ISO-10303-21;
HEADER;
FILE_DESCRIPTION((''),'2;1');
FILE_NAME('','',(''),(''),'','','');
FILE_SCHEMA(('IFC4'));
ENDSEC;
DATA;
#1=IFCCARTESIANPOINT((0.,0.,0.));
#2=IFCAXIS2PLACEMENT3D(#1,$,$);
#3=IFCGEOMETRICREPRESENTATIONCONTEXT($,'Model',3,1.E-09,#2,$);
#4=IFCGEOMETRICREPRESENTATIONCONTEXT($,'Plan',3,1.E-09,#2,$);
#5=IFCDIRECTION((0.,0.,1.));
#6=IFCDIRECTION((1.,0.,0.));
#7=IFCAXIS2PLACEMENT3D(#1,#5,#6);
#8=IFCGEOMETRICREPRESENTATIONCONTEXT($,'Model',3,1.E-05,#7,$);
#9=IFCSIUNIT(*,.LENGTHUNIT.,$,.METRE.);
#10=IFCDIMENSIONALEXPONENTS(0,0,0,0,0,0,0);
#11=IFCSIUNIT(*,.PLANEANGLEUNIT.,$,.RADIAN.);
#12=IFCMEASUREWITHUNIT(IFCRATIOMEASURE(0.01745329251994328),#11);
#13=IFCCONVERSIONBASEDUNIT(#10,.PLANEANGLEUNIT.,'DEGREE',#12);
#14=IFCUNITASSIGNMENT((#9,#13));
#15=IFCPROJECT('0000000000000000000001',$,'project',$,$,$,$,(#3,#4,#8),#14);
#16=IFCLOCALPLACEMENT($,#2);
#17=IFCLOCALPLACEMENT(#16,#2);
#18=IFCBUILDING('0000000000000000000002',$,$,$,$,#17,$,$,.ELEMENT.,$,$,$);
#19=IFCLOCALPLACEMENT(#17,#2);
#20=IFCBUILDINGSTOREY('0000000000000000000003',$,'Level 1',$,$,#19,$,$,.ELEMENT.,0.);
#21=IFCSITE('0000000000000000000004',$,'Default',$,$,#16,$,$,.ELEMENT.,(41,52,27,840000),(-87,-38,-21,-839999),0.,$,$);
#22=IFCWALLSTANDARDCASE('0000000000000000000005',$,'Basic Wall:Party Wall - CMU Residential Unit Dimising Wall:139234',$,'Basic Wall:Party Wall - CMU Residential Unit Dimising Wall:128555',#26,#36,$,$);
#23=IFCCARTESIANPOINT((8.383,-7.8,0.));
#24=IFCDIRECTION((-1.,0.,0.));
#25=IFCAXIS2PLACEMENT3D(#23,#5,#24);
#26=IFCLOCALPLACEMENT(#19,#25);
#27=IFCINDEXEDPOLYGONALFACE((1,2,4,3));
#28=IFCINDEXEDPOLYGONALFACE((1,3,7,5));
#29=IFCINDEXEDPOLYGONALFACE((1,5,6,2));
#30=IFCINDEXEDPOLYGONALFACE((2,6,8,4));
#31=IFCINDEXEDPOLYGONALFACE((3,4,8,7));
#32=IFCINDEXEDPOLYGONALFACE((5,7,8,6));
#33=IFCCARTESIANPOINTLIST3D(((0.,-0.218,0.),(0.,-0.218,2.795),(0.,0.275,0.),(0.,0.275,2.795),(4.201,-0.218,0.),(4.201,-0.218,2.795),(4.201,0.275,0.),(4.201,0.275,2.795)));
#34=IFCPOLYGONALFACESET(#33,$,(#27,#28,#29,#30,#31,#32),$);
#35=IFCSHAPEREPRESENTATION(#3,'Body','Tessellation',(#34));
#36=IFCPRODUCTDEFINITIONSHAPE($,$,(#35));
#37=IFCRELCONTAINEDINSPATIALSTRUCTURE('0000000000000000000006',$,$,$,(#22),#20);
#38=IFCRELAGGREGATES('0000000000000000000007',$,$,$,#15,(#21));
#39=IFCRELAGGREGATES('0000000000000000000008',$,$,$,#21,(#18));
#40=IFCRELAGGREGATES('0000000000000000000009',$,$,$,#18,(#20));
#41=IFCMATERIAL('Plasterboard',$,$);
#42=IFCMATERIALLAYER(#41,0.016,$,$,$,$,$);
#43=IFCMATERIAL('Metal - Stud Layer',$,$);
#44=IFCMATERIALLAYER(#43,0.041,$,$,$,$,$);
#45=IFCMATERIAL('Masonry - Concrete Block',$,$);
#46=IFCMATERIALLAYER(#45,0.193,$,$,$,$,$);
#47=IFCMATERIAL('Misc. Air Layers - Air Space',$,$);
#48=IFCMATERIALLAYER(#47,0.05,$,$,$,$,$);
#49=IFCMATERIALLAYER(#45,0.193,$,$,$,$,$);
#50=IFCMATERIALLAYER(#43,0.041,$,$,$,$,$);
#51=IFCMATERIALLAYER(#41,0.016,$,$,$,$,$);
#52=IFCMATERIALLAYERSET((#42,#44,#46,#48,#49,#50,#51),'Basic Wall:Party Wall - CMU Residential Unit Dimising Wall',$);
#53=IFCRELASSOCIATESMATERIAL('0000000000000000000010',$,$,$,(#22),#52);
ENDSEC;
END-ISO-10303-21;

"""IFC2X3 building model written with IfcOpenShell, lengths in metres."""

from ifc_helpers import new_model, entity, si_unit, converted_unit, frame, frame_2d, origin, origin_with_axes, place, context, project, spatial, polyline, rectangle, extrude, clip, bounded_halfspace, material, layer, layer_set, layer_usage, element, save


model = new_model("IFC2X3")

# Units and contexts
model_context_1 = context("Model", 3, precision=1e-09, world=origin())
plan_context = context("Plan", 3, precision=1e-09, world=origin())
model_context_2 = context("Model", 3, precision=1e-05, world=origin_with_axes())
ifc_project = project(units=[si_unit("LENGTHUNIT", "METRE"), converted_unit("PLANEANGLEUNIT", "DEGREE", entity("IfcRatioMeasure", 0.01745329251994328), si_unit("PLANEANGLEUNIT", "RADIAN"), dimensions=[0, 0, 0, 0, 0, 0, 0])], contexts=[model_context_1, plan_context, model_context_2])

# Site, building, storey
site_placement = place(None, origin())
site = spatial("IfcSite", under=ifc_project, at=site_placement, Name="Default", CompositionType="ELEMENT", RefLatitude=(41, 52, 27, 840000), RefLongitude=(-87, -38, -21, -839999), RefElevation=0.0)
building_placement = place(site_placement, origin())
building = spatial("IfcBuilding", under=site, at=building_placement, CompositionType="ELEMENT")
storey_placement = place(building_placement, origin())
storey = spatial("IfcBuildingStorey", under=building, at=storey_placement, Name="Level 1", CompositionType="ELEMENT", Elevation=0.0)

# Wall
ifc_material_1 = material(Name="Plasterboard")
ifc_layer_1 = layer(ifc_material_1, 0.016)
ifc_material_2 = material(Name="Metal - Stud Layer")
ifc_layer_2 = layer(ifc_material_2, 0.041)
ifc_material_3 = material(Name="Masonry - Concrete Block")
ifc_layer_3 = layer(ifc_material_3, 0.193)
ifc_material_4 = material(Name="Misc. Air Layers - Air Space")
ifc_layer_4 = layer(ifc_material_4, 0.05)
ifc_layer_5 = layer(ifc_material_3, 0.193)
ifc_layer_6 = layer(ifc_material_2, 0.041)
ifc_layer_7 = layer(ifc_material_1, 0.016)
ifc_layer_set_1 = layer_set([ifc_layer_1, ifc_layer_2, ifc_layer_3, ifc_layer_4, ifc_layer_5, ifc_layer_6, ifc_layer_7], Name="Basic Wall:Party Wall - CMU Residential Unit Dimising Wall")
ifc_layer_usage_1 = layer_usage(ifc_layer_set_1, "AXIS2", "NEGATIVE", 0.275)
wall_1_placement = place(storey_placement, frame((8.383, -7.8, 0.0), z_axis=(0.0, 0.0, 1.0), x_axis=(-1.0, 0.0, 0.0)))
element("IfcWallStandardCase", 1, at=wall_1_placement, inside=storey, material=ifc_layer_usage_1, Name="Basic Wall:Party Wall - CMU Residential Unit Dimising Wall:139234", ObjectType="Basic Wall:Party Wall - CMU Residential Unit Dimising Wall:128555", context=model_context_1, shape_type="Clipping", body=[
    clip(clip(extrude(rectangle(XDim=4.201, YDim=0.55, at=frame_2d((2.1005, 0.0), x_axis=(-1.0, 0.0))), origin(), (0.0, 0.0, 1.0), 2.795), bounded_halfspace(frame((0.0, -0.218, 2.795), z_axis=(0.0, 1.0, 0.0), x_axis=(-1.0, 0.0, 0.0)), True, frame((0.0, -0.218, 2.795), z_axis=(0.0, 1.0, 0.0), x_axis=(-1.0, 0.0, 0.0)), polyline([(0.0, 0.0), (-3.708, 0.0), (-4.201, 0.0), (-4.201, -2.795), (0.0, -2.795), (0.0, 0.0)]))), bounded_halfspace(frame((4.201, 0.275, 0.0), z_axis=(-1.0, 0.0, 0.0), x_axis=(0.0, -1.0, 0.0)), True, frame((4.201, 0.275, 0.0), z_axis=(-1.0, 0.0, 0.0), x_axis=(0.0, -1.0, 0.0)), polyline([(0.0, 0.0), (0.493, 0.0), (0.493, 2.795), (0.0, 2.795), (0.0, 0.0)]))),
])

save(model, "model.ifc")
